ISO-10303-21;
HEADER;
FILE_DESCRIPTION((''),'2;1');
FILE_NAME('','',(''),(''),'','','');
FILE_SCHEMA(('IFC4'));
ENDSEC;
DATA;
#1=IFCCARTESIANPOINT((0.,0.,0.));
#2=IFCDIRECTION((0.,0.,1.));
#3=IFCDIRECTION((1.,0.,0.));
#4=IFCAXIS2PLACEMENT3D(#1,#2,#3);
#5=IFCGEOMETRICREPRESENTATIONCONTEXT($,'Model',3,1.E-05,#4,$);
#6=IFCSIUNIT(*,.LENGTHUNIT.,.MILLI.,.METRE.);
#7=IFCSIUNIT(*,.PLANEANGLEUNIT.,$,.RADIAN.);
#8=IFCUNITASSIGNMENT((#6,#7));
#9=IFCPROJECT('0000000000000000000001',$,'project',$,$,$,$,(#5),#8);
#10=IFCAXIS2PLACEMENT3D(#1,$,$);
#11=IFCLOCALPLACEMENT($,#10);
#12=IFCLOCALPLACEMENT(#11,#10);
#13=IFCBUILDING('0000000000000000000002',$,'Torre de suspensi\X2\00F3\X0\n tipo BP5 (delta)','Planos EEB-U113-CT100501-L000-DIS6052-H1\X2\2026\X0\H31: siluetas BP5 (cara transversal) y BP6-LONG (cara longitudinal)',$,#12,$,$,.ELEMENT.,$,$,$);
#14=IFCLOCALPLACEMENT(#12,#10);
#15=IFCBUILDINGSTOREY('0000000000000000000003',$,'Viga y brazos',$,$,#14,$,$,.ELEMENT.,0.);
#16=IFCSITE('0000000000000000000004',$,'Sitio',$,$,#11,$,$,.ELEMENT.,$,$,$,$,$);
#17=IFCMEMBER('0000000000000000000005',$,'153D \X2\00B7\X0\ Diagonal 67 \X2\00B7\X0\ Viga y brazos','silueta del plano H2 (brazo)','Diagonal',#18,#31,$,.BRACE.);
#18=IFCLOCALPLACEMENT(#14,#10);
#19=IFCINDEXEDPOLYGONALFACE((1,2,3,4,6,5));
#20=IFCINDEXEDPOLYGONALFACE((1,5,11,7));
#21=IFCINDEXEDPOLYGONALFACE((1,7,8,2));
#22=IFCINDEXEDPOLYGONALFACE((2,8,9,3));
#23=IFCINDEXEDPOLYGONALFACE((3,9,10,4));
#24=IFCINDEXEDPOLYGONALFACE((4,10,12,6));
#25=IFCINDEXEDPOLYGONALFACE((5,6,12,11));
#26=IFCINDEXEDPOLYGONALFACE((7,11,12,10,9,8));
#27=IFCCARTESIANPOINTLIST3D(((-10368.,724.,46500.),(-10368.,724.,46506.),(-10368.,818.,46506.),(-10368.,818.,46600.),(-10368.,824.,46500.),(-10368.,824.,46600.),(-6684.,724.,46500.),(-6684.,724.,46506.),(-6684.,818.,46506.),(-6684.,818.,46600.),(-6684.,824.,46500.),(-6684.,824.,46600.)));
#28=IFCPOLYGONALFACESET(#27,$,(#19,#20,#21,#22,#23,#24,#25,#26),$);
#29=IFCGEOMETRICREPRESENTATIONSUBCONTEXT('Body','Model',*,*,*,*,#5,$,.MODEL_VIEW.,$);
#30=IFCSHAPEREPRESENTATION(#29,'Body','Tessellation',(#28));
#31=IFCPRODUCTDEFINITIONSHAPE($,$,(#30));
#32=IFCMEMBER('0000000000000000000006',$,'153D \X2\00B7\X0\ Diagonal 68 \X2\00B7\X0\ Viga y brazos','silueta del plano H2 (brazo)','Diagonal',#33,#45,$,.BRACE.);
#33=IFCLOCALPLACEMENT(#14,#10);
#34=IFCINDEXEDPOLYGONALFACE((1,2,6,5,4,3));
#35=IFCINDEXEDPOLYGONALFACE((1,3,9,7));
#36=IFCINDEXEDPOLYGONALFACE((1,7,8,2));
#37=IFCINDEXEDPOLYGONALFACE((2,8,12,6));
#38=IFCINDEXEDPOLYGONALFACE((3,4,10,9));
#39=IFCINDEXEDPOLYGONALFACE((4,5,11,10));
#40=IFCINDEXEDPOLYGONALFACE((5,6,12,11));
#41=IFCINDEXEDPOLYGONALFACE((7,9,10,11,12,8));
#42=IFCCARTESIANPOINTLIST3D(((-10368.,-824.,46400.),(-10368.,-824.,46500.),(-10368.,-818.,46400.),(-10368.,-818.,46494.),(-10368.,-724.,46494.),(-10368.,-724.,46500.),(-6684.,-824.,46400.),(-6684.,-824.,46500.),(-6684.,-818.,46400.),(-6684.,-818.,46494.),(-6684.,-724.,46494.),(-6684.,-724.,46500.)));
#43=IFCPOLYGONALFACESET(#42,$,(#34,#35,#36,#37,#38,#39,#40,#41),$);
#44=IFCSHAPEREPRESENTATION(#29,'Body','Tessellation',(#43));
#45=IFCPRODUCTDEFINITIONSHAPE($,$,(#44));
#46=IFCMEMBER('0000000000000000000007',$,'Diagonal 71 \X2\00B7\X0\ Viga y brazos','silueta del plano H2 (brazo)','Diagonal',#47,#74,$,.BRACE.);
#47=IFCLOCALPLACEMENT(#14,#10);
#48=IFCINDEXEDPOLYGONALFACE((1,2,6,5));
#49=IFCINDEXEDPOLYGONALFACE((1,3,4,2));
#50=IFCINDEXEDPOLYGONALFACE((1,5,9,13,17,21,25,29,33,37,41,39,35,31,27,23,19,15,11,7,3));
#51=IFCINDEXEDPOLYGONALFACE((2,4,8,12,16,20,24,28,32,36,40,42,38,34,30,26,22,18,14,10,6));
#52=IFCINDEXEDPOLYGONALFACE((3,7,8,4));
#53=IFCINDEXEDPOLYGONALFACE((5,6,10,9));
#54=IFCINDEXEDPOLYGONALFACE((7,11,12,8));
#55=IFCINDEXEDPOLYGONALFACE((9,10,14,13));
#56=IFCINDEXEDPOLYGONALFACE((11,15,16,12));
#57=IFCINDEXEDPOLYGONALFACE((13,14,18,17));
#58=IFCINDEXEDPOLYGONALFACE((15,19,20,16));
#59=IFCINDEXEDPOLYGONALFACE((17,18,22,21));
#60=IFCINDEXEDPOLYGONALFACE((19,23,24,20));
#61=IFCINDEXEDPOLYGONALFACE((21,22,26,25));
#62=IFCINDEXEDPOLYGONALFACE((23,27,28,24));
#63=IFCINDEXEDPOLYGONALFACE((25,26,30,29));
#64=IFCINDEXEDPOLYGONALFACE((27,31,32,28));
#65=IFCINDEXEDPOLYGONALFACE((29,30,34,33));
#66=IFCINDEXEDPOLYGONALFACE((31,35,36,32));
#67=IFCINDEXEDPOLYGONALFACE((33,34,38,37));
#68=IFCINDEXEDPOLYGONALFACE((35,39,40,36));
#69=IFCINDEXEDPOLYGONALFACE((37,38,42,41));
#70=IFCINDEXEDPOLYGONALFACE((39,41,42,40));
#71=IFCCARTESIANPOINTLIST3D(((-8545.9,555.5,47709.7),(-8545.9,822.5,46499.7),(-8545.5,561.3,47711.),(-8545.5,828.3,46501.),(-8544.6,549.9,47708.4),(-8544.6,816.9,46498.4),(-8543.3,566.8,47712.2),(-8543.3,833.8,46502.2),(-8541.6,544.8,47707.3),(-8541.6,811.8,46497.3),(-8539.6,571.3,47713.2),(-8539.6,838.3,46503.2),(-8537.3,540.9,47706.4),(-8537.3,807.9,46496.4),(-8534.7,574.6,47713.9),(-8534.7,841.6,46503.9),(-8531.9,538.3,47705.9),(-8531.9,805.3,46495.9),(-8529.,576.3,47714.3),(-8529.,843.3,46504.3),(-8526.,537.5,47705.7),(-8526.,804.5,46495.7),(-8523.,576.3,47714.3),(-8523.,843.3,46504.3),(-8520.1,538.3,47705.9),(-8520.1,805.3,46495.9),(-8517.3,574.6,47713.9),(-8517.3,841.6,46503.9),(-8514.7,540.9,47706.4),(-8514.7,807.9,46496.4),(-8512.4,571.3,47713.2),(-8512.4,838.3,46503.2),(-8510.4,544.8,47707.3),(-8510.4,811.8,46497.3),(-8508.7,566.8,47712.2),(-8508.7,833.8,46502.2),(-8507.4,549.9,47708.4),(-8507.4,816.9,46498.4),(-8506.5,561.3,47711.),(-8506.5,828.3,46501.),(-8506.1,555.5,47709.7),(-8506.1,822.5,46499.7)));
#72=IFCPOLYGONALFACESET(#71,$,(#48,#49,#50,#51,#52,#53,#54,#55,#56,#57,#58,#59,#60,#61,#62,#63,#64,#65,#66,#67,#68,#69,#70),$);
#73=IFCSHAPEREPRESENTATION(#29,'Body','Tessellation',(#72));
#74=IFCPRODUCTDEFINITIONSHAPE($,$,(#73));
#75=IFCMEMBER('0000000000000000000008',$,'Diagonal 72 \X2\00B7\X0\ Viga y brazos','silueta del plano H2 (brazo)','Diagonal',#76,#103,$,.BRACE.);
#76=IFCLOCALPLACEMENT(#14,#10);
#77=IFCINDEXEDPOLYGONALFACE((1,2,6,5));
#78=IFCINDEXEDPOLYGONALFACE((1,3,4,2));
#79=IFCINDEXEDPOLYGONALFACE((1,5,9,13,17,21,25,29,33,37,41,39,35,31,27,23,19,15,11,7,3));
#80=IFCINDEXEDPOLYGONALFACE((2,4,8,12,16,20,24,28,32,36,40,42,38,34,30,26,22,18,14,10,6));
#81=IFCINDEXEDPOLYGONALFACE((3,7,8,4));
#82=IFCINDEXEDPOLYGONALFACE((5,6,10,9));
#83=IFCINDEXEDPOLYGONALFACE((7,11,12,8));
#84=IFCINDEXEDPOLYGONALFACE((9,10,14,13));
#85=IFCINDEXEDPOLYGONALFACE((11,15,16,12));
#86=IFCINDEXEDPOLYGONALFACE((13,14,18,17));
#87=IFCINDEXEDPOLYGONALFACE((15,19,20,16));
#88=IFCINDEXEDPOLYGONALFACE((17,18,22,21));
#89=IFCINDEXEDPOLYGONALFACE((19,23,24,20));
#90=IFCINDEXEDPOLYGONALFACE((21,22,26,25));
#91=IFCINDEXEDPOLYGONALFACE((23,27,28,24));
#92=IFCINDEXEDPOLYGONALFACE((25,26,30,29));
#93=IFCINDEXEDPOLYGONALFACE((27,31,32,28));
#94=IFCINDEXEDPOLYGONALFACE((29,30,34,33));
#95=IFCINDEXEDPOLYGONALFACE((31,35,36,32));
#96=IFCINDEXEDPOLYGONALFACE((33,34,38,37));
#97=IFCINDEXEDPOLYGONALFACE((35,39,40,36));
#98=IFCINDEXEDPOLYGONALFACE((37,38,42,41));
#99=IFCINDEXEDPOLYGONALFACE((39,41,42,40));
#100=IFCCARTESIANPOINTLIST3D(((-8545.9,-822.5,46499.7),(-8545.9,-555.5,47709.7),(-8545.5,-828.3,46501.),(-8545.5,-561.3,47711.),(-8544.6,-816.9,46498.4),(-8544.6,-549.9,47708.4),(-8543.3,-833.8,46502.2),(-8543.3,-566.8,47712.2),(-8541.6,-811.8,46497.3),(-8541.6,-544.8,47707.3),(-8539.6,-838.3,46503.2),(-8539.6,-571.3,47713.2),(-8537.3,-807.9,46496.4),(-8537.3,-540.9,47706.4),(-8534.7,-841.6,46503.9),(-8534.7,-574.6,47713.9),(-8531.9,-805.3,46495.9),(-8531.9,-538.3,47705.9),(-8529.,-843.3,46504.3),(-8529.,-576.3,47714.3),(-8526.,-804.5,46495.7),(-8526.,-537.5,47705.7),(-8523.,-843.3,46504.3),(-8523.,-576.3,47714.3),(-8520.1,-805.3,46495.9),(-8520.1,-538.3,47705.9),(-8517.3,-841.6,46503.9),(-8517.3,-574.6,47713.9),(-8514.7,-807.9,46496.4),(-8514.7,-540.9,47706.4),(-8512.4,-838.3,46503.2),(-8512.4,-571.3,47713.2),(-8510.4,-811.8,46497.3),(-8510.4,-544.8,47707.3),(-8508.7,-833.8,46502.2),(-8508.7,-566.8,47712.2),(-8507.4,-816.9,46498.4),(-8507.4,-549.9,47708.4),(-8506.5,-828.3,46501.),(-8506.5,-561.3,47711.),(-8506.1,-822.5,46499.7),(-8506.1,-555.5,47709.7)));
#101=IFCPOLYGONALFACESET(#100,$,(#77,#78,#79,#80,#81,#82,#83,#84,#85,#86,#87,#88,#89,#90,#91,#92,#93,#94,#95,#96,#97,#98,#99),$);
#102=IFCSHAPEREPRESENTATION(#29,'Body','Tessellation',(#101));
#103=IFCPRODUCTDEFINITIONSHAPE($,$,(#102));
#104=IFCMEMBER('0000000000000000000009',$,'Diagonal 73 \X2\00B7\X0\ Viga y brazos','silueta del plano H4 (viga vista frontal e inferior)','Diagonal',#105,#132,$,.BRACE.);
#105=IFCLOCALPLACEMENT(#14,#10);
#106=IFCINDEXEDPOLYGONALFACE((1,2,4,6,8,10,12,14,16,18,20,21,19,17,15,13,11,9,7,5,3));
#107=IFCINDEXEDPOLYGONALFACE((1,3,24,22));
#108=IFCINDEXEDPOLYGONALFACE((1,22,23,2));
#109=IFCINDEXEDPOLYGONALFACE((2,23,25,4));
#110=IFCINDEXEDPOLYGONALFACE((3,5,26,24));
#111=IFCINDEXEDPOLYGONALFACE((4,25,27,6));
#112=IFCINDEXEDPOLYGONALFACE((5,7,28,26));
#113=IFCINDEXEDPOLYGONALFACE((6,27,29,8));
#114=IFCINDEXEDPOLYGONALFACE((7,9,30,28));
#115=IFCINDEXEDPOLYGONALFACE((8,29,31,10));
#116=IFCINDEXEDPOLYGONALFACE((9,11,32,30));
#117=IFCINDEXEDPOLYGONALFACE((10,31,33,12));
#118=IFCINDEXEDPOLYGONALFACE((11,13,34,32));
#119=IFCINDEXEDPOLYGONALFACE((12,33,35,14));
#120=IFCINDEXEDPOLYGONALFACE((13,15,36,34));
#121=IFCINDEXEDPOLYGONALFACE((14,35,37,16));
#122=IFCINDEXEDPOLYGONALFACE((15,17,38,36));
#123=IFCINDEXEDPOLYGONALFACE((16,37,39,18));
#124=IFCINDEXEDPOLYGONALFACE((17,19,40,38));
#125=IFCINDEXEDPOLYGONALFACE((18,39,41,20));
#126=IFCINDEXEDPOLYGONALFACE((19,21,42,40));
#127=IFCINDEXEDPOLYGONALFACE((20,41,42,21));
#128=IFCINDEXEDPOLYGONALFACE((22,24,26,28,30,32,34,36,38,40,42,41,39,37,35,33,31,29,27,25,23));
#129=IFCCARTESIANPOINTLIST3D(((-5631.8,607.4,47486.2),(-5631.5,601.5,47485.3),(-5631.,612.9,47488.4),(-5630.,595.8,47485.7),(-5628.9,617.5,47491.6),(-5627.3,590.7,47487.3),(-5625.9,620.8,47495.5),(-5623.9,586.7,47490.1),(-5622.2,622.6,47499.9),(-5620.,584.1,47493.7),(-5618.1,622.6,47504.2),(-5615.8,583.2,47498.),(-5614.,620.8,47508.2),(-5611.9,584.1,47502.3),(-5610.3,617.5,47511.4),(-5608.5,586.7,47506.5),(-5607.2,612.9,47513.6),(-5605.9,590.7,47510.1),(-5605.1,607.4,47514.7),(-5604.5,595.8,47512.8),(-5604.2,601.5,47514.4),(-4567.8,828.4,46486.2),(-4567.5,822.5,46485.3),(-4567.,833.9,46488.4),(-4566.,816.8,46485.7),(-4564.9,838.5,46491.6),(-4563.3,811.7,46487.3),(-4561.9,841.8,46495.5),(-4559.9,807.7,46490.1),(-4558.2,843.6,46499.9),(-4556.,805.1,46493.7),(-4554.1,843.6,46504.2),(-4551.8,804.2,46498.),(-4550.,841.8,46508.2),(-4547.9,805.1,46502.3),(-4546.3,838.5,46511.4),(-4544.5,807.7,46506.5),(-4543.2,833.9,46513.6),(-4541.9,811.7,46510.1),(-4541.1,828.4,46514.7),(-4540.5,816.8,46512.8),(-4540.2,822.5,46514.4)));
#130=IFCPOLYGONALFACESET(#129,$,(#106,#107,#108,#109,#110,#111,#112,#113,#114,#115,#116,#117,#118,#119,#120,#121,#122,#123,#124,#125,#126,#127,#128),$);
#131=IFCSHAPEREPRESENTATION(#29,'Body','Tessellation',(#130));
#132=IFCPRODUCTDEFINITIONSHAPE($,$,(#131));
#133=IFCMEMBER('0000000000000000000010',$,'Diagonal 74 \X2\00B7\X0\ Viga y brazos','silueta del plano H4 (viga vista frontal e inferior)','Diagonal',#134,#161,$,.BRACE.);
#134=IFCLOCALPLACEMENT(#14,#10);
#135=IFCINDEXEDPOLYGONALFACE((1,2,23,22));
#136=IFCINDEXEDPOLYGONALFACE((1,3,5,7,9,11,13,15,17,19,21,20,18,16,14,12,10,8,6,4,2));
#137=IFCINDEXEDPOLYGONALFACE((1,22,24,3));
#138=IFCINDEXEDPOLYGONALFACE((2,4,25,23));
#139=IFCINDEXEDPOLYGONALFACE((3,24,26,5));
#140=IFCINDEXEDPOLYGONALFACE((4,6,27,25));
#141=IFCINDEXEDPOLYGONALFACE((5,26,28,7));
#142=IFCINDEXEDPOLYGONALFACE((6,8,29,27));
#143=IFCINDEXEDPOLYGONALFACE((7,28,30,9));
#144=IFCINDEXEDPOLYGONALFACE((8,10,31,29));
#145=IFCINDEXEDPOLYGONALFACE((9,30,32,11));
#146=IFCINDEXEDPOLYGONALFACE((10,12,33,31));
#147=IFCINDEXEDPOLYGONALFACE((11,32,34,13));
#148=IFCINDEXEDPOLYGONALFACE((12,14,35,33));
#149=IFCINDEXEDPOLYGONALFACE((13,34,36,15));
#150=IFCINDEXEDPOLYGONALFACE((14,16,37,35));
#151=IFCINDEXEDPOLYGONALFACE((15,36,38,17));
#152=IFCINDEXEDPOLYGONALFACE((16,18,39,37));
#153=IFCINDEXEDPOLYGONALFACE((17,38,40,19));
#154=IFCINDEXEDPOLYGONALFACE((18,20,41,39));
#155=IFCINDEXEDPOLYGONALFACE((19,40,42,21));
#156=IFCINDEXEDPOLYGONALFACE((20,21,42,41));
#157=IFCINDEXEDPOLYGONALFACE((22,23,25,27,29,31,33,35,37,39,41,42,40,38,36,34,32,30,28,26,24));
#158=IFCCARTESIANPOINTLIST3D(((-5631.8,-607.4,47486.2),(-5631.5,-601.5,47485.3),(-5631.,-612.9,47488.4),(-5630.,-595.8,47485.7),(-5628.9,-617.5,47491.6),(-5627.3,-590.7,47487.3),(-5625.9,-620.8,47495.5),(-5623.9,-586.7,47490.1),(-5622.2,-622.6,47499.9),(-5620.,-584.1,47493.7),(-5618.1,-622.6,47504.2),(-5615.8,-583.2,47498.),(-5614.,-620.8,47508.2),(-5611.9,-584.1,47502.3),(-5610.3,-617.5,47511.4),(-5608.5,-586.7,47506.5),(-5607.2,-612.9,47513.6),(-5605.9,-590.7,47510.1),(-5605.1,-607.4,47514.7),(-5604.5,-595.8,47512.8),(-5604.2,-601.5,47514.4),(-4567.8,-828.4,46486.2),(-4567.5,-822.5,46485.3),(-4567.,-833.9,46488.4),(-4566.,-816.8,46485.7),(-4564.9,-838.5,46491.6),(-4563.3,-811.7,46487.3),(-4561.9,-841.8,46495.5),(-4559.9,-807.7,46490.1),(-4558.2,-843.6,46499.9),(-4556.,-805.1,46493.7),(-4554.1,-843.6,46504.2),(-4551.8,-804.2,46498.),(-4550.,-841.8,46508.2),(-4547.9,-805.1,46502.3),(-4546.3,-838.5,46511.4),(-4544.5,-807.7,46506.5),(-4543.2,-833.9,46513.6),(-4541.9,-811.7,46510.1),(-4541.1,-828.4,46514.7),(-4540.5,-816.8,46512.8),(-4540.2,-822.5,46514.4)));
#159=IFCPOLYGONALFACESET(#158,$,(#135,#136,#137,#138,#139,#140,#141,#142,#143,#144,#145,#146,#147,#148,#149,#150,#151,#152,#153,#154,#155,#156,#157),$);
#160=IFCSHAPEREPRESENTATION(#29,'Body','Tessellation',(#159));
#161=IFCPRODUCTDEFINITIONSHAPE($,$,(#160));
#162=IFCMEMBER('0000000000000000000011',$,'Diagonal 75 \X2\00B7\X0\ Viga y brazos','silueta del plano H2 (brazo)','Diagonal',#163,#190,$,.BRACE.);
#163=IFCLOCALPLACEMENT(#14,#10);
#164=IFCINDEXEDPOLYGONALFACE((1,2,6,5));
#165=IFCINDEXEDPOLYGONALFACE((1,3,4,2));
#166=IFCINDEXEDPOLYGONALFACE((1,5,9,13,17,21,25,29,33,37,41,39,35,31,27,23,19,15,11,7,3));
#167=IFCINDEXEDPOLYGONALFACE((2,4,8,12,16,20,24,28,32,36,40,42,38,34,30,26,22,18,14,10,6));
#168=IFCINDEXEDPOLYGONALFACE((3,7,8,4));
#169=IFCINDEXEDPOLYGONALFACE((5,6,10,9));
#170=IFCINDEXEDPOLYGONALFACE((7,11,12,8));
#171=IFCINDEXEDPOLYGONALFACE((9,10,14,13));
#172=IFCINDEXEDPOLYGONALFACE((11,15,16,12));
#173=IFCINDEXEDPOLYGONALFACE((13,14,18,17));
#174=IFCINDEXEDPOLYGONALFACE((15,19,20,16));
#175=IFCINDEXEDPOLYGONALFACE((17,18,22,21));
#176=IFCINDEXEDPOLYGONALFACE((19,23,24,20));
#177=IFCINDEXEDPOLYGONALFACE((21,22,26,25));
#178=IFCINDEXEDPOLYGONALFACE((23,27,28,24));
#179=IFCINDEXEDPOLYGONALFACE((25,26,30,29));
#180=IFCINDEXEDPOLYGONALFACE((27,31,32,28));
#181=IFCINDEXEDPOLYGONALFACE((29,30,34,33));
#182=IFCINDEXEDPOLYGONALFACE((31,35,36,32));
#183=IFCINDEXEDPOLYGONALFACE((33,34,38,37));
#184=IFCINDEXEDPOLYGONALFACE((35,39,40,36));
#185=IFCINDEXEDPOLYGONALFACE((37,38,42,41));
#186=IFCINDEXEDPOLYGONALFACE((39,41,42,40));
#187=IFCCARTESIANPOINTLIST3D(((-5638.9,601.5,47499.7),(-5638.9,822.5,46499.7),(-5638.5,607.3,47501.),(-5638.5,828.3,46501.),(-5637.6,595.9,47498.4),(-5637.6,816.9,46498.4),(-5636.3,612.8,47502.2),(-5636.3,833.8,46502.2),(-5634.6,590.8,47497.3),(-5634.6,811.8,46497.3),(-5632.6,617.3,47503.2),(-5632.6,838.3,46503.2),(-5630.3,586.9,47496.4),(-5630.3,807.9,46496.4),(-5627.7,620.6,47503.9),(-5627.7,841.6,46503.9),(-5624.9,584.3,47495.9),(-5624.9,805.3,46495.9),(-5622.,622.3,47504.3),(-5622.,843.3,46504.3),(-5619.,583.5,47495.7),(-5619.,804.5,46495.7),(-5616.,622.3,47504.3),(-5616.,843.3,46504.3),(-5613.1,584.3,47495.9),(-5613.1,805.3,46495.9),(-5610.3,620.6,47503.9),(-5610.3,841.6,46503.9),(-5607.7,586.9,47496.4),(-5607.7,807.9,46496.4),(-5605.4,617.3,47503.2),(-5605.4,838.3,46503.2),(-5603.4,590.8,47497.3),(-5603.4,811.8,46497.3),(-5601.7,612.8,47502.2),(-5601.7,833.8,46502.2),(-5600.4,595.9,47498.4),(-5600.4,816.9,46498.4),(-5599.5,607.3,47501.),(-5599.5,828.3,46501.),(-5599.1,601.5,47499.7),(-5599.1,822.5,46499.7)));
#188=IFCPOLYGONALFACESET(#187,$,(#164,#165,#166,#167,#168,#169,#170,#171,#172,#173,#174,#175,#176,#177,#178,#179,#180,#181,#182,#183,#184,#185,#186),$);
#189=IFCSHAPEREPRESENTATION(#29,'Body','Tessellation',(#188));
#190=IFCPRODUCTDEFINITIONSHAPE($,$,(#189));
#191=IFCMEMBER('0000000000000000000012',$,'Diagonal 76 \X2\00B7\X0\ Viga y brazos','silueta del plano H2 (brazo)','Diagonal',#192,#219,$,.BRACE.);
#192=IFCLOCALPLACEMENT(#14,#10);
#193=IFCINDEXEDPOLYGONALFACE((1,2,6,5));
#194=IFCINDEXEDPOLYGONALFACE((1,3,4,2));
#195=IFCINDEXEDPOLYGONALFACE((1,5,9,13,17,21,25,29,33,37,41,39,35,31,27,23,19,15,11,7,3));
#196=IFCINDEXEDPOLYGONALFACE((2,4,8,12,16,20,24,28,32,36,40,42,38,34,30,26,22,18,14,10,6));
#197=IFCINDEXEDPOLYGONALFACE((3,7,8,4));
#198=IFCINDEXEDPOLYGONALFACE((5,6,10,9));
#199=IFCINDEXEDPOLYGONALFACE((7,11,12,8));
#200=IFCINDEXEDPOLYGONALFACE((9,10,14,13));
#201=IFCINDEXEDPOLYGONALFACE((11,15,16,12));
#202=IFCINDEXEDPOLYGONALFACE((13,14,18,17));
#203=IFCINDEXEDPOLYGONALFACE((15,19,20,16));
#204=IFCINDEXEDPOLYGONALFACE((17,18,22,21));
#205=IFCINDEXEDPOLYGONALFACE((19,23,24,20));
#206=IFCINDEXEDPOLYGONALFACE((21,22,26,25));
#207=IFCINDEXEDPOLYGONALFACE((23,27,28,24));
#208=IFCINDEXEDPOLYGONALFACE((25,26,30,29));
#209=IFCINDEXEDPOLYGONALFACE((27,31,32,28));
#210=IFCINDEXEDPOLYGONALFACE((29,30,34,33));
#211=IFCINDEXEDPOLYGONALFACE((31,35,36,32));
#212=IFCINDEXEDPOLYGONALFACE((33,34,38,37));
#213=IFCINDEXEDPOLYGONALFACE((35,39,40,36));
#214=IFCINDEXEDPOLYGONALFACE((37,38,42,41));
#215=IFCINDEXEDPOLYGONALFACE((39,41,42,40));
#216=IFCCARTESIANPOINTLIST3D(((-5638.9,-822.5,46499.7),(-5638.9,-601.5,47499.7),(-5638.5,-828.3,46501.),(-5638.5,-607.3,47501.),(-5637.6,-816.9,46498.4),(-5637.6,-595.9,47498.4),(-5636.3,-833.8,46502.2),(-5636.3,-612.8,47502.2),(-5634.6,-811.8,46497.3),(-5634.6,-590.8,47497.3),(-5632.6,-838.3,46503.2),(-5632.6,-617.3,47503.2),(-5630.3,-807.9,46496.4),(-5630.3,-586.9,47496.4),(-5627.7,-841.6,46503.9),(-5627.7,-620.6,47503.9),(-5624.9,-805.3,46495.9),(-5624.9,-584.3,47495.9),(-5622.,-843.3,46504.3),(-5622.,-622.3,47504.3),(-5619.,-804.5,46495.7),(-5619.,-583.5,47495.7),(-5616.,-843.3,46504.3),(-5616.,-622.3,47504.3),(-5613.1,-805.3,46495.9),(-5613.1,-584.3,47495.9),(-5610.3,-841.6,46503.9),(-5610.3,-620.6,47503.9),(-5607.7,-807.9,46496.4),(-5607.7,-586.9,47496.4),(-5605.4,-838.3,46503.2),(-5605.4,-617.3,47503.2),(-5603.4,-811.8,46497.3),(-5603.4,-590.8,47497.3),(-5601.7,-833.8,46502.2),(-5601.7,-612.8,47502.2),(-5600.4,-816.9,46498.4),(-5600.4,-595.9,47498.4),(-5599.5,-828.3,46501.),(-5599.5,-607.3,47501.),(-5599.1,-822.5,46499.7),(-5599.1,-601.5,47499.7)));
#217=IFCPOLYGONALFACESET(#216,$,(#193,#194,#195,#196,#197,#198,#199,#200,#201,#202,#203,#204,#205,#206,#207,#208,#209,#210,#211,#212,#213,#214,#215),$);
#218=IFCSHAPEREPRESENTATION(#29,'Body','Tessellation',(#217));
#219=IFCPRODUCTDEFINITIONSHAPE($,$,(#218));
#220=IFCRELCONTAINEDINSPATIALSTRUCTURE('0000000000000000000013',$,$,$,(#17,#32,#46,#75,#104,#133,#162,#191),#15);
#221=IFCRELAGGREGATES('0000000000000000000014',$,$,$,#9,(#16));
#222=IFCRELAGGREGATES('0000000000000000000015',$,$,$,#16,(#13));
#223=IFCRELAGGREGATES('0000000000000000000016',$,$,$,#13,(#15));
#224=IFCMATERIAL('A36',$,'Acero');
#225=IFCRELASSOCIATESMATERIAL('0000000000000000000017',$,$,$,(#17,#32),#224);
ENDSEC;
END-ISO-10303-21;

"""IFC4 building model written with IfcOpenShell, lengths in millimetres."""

from ifc_helpers import new_model, si_unit, frame, frame_2d, origin, origin_with_axes, place, context, subcontext, project, spatial, circle, l_section, extrude, material, element, save


model = new_model("IFC4")

# Units and contexts
model_context = context("Model", 3, precision=1e-05, world=origin_with_axes())
body_context = subcontext(model_context, "Body", "Model", "MODEL_VIEW")
ifc_project = project(units=[si_unit("LENGTHUNIT", "METRE", prefix="MILLI"), si_unit("PLANEANGLEUNIT", "RADIAN")], contexts=[model_context])

# Site, building, storey
site_placement = place(None, origin())
site = spatial("IfcSite", under=ifc_project, at=site_placement, Name="Sitio", CompositionType="ELEMENT")
building_placement = place(site_placement, origin())
building = spatial("IfcBuilding", under=site, at=building_placement, Name="Torre de suspensión tipo BP5 (delta)", Description="Planos EEB-U113-CT100501-L000-DIS6052-H1…H31: siluetas BP5 (cara transversal) y BP6-LONG (cara longitudinal)", CompositionType="ELEMENT")
storey_placement = place(building_placement, origin())
storey = spatial("IfcBuildingStorey", under=building, at=storey_placement, Name="Viga y brazos", CompositionType="ELEMENT", Elevation=0.0)

# Members
ifc_material_1 = material(Name="A36", Category="Acero")
for number, where, z_axis, x_axis, name in (
    (1, (-6684.0, 824.0, 46500.0), (-1.0, 0.0, 0.0), (0.0, -1.0, 0.0), "153D · Diagonal 67 · Viga y brazos"),
    (2, (-6684.0, -824.0, 46500.0), (-1.0, 0.0, 0.0), (0.0, 1.0, 0.0), "153D · Diagonal 68 · Viga y brazos"),
):
    element("IfcMember", number, at=place(storey_placement, frame(where, z_axis=z_axis, x_axis=x_axis)), inside=storey, material=ifc_material_1, Name=name, Description="silueta del plano H2 (brazo)", ObjectType="Diagonal", PredefinedType="BRACE", context=body_context, shape_type="SweptSolid", body=[
        extrude(l_section(Depth=100.0, Width=100.0, Thickness=6.0, at=frame_2d((50.0, 50.0))), None, (0.0, 0.0, 1.0), 3684.0),
    ])
for number, where, z_axis, x_axis, name in (
    (3, (-8526.0, 557.0, 47710.0), (0.0, 0.215478, -0.976509), (0.0, -0.976509, -0.215478), "Diagonal 71 · Viga y brazos"),
    (4, (-8526.0, -557.0, 47710.0), (0.0, -0.215478, -0.976509), (0.0, 0.976509, -0.215478), "Diagonal 72 · Viga y brazos"),
):
    element("IfcMember", number, at=place(storey_placement, frame(where, z_axis=z_axis, x_axis=x_axis)), inside=storey, Name=name, Description="silueta del plano H2 (brazo)", ObjectType="Diagonal", PredefinedType="BRACE", context=body_context, shape_type="SweptSolid", body=[
        extrude(circle(Radius=20.0), None, (0.0, 0.0, 1.0), 1239.1),
    ])
for number, where, z_axis, x_axis, name in (
    (5, (-4554.0, 824.0, 46500.0), (-0.720477, -0.149648, 0.67714), (0.109046, -0.988739, -0.102487), "Diagonal 73 · Viga y brazos"),
    (6, (-4554.0, -824.0, 46500.0), (-0.720477, 0.149648, 0.67714), (0.109046, 0.988739, -0.102487), "Diagonal 74 · Viga y brazos"),
):
    element("IfcMember", number, at=place(storey_placement, frame(where, z_axis=z_axis, x_axis=x_axis)), inside=storey, Name=name, Description="silueta del plano H4 (viga vista frontal e inferior)", ObjectType="Diagonal", PredefinedType="BRACE", context=body_context, shape_type="SweptSolid", body=[
        extrude(circle(Radius=20.0), None, (0.0, 0.0, 1.0), 1476.8),
    ])
for number, where, z_axis, x_axis, name in (
    (7, (-5619.0, 824.0, 46500.0), (0.0, -0.215793, 0.976439), (0.0, -0.976439, -0.215793), "Diagonal 75 · Viga y brazos"),
    (8, (-5619.0, -824.0, 46500.0), (0.0, 0.215793, 0.976439), (0.0, 0.976439, -0.215793), "Diagonal 76 · Viga y brazos"),
):
    element("IfcMember", number, at=place(storey_placement, frame(where, z_axis=z_axis, x_axis=x_axis)), inside=storey, Name=name, Description="silueta del plano H2 (brazo)", ObjectType="Diagonal", PredefinedType="BRACE", context=body_context, shape_type="SweptSolid", body=[
        extrude(circle(Radius=20.0), None, (0.0, 0.0, 1.0), 1024.1),
    ])

save(model, "model.ifc")
